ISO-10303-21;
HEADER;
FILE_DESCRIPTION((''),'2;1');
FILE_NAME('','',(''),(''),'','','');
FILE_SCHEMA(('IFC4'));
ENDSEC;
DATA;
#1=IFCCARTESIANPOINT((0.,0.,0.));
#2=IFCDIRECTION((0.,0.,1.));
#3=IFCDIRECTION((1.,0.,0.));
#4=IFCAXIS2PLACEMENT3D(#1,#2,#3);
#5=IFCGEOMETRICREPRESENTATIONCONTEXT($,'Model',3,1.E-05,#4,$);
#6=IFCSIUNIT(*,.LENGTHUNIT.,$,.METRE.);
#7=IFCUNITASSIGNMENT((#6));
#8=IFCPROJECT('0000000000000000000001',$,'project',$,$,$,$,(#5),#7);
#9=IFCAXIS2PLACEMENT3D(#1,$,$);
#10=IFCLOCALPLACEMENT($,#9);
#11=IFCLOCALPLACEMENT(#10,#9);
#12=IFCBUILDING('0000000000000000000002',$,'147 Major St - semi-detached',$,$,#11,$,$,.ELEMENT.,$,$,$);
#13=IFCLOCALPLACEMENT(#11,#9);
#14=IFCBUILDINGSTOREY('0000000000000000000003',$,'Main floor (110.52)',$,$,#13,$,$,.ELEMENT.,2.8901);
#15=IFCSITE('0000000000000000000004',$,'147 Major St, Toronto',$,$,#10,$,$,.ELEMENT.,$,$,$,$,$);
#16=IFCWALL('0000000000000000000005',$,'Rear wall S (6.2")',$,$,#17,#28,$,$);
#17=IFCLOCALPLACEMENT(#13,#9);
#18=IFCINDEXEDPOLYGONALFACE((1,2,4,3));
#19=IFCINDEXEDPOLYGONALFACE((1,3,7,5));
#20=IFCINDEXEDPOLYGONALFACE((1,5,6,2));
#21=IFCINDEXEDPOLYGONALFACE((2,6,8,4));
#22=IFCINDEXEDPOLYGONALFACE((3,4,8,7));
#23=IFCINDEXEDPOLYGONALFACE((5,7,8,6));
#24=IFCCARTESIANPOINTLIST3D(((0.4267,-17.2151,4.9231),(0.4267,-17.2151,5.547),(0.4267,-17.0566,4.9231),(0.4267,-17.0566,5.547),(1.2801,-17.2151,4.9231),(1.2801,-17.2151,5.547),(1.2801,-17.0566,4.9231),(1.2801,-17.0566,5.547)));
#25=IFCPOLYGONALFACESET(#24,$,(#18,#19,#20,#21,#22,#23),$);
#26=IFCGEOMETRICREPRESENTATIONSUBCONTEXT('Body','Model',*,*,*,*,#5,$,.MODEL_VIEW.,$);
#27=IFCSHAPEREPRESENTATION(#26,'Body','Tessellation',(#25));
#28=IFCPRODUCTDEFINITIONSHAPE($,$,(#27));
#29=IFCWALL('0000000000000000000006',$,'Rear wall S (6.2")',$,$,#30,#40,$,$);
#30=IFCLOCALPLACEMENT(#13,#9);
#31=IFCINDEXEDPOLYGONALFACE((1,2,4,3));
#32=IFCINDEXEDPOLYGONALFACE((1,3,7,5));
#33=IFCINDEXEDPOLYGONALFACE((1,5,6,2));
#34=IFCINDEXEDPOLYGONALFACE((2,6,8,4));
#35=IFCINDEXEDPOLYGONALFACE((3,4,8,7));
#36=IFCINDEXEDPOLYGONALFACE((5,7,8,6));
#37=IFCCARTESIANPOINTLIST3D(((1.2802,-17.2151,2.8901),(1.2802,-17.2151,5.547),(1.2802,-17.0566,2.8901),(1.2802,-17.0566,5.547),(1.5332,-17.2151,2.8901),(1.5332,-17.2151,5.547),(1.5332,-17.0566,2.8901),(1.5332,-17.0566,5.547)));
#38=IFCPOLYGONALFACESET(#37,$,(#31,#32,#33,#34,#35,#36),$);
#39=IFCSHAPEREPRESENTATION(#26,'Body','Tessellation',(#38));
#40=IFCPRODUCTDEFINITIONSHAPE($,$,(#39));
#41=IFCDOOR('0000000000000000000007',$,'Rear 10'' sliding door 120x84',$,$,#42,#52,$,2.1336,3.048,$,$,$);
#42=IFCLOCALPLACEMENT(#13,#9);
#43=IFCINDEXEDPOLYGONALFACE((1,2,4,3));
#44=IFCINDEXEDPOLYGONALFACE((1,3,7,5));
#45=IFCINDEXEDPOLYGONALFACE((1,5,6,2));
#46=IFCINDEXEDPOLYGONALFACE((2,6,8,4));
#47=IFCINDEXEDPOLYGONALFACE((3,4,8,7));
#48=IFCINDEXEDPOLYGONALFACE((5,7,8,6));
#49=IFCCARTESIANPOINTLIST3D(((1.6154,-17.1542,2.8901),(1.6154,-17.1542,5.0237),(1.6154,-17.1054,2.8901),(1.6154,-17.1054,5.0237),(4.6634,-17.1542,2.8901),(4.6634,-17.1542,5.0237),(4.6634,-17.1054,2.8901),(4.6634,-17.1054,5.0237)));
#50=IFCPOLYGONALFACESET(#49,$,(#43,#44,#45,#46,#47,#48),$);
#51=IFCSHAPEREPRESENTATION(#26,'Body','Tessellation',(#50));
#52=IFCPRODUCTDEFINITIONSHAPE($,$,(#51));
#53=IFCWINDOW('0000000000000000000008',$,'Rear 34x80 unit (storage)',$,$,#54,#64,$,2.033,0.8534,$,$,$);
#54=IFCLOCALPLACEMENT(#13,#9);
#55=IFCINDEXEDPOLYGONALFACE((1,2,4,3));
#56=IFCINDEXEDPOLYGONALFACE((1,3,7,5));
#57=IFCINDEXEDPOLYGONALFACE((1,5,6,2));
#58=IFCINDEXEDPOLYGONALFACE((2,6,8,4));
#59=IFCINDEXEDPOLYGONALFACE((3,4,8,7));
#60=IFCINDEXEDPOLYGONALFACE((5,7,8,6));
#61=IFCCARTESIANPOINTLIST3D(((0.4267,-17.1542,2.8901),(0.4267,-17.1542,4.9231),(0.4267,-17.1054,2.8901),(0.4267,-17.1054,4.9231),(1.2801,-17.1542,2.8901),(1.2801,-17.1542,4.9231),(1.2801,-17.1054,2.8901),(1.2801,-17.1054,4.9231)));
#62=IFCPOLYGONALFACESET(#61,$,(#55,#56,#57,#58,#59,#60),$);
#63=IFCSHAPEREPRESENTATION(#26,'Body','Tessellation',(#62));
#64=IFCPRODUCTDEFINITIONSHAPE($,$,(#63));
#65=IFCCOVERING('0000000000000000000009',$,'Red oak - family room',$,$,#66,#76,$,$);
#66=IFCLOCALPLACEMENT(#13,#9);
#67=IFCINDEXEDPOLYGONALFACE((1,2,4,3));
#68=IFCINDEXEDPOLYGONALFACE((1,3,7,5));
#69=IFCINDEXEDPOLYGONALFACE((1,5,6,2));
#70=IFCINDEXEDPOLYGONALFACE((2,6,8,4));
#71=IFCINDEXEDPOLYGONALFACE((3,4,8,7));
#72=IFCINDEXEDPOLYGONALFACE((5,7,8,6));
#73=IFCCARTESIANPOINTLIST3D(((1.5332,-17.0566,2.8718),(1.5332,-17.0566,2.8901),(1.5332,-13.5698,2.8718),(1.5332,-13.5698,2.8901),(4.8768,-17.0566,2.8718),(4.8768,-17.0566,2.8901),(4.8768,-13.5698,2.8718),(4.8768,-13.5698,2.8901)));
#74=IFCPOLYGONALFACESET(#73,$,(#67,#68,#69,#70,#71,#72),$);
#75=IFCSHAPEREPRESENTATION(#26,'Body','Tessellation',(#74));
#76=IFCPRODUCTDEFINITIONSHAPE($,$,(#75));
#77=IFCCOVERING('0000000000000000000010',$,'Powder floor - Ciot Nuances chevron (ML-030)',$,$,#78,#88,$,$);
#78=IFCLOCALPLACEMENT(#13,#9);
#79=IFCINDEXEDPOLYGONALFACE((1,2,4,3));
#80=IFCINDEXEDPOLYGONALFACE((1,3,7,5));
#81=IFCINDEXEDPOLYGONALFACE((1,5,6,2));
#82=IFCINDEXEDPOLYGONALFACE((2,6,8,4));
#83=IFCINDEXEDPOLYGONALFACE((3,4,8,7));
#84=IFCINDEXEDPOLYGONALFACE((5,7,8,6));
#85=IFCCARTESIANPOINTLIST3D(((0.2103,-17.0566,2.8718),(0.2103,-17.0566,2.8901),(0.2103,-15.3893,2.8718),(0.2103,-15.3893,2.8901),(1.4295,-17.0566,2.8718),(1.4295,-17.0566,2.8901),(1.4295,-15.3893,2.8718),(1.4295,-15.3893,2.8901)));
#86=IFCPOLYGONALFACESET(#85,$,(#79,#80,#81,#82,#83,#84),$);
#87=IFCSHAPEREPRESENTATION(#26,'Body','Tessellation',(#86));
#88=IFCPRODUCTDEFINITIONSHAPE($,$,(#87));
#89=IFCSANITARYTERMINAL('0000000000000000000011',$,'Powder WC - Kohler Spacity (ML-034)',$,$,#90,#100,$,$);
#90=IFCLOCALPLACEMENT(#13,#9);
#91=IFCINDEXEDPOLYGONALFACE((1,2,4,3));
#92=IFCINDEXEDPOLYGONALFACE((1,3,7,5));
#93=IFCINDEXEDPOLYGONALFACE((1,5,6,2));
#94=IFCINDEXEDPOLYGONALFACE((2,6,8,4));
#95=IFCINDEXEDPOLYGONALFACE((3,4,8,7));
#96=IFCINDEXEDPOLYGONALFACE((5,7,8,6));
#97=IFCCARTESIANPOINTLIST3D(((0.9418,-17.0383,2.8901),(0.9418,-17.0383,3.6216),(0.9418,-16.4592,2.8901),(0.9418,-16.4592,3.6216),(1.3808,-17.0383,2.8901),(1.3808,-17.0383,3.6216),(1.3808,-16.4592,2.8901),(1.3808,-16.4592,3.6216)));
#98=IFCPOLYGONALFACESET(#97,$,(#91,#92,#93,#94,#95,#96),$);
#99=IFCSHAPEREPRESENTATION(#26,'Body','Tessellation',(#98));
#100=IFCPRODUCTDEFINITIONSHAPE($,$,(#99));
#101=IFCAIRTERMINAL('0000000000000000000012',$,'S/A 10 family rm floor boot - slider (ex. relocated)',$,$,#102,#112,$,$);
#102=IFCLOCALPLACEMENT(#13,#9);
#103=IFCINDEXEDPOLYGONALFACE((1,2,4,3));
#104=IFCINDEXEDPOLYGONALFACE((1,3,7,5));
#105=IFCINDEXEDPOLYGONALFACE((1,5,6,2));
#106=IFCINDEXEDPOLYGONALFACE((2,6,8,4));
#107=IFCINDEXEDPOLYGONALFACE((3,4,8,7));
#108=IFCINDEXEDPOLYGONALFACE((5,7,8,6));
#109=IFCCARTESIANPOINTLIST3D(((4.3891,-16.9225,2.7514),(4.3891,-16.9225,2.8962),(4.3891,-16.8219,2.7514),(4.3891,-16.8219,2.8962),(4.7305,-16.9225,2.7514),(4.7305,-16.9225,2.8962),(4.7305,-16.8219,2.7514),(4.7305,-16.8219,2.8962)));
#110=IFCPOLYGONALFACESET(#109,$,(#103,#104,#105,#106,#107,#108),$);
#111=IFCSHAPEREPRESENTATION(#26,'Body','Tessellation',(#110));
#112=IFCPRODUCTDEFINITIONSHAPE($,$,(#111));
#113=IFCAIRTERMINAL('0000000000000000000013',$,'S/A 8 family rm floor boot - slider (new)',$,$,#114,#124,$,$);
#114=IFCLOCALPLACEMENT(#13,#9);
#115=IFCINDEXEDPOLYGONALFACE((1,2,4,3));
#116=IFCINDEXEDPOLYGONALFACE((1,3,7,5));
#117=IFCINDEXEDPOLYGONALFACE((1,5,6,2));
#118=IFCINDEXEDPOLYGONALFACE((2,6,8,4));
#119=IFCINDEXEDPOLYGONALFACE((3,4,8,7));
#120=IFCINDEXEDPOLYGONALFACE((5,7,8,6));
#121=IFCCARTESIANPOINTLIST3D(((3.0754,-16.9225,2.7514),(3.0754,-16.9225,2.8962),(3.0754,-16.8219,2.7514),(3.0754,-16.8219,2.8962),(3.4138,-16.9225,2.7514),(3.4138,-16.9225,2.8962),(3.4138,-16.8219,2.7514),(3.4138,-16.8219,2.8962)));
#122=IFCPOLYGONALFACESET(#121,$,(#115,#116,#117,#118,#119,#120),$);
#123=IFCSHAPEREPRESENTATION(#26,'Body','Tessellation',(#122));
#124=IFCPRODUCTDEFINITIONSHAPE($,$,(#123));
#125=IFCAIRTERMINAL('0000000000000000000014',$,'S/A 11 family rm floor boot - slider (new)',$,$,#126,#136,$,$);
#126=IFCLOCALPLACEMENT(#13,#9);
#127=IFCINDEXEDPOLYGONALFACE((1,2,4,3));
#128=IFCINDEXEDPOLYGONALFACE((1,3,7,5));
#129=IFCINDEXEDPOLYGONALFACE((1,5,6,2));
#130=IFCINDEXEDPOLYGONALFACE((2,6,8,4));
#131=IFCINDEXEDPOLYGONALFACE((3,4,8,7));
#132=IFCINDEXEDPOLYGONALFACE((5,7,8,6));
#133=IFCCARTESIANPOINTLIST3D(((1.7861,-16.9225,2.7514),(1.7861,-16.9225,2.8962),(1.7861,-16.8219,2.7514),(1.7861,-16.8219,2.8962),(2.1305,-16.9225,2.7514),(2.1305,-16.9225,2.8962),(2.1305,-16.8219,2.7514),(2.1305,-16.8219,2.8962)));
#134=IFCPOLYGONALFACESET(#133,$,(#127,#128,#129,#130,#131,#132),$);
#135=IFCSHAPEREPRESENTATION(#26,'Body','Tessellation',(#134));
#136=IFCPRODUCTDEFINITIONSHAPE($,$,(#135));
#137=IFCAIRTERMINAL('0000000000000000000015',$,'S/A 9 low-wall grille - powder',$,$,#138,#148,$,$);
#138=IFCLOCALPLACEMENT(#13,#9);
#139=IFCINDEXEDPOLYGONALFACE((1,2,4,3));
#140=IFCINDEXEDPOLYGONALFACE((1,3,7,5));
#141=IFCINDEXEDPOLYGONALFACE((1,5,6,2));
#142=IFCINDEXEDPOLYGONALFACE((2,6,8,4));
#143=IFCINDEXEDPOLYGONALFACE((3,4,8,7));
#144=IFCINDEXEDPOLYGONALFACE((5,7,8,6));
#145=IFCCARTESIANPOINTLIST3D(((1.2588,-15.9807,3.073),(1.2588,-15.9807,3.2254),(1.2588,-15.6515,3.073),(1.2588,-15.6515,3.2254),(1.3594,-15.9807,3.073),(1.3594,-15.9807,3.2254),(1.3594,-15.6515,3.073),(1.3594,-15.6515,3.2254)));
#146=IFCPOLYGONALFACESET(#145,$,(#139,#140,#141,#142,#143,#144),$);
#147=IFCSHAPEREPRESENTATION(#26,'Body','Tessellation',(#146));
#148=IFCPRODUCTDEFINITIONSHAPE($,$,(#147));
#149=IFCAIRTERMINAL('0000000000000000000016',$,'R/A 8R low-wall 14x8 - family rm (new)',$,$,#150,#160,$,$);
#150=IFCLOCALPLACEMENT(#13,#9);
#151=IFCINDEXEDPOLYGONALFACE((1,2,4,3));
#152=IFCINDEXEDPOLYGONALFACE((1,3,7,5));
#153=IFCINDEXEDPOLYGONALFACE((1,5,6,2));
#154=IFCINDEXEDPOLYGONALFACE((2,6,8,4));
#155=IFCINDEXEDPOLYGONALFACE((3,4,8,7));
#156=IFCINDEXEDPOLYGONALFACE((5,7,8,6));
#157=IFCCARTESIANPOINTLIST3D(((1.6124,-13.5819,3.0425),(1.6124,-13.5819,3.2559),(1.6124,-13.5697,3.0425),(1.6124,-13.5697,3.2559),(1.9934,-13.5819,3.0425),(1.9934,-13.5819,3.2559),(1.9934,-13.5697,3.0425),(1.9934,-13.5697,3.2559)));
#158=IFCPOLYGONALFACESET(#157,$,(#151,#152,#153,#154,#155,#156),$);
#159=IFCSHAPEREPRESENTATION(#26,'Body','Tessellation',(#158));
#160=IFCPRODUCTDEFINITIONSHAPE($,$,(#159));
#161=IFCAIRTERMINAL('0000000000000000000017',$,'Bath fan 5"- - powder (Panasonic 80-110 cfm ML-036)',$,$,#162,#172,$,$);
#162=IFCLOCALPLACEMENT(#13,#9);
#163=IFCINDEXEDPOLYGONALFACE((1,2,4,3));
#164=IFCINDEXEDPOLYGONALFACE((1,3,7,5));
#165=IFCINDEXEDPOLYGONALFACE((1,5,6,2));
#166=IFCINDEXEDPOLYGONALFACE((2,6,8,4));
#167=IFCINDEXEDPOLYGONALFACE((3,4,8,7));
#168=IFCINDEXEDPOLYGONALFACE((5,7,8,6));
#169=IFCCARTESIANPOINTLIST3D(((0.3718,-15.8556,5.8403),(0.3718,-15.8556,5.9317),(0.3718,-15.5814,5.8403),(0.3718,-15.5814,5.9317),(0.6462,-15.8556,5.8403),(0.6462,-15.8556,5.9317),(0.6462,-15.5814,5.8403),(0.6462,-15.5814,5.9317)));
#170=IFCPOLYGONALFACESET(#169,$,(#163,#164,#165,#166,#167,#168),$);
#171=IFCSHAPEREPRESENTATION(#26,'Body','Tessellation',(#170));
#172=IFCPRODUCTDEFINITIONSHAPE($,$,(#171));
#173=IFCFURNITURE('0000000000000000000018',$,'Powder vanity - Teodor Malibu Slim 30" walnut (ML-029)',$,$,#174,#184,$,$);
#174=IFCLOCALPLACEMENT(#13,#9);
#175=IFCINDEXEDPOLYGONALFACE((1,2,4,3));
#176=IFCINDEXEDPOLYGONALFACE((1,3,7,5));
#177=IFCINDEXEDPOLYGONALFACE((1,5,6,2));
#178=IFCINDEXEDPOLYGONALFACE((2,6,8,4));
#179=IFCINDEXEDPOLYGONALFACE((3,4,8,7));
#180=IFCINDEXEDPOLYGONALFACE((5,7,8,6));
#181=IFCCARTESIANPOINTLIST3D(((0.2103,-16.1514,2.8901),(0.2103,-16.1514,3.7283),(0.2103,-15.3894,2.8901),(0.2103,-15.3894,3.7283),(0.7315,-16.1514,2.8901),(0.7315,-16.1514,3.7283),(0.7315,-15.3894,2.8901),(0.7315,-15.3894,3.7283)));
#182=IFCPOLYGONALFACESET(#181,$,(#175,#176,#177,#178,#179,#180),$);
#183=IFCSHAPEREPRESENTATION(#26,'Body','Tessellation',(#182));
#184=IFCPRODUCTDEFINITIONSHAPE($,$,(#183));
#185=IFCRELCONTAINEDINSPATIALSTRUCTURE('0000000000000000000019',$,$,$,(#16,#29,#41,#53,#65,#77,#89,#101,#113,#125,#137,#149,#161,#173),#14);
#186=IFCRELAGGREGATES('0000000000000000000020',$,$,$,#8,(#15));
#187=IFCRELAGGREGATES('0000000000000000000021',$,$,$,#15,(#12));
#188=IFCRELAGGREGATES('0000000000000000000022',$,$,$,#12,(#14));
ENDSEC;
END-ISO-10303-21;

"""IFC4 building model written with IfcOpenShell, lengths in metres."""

from ifc_helpers import new_model, si_unit, frame, origin, origin_with_axes, place, context, subcontext, project, spatial, rectangle, extrude, element, save


model = new_model("IFC4")

# Units and contexts
model_context = context("Model", 3, precision=1e-05, world=origin_with_axes())
body_context = subcontext(model_context, "Body", "Model", "MODEL_VIEW")
ifc_project = project(units=[si_unit("LENGTHUNIT", "METRE")], contexts=[model_context])

# Site, building, storey
site_placement = place(None, origin())
site = spatial("IfcSite", under=ifc_project, at=site_placement, Name="147 Major St, Toronto", CompositionType="ELEMENT")
building_placement = place(site_placement, origin())
building = spatial("IfcBuilding", under=site, at=building_placement, Name="147 Major St - semi-detached", CompositionType="ELEMENT")
storey_placement = place(building_placement, origin())
storey = spatial("IfcBuildingStorey", under=building, at=storey_placement, Name="Main floor (110.52)", CompositionType="ELEMENT", Elevation=2.8901)

# Walls
wall_1_placement = place(storey_placement, frame((0.8534, -17.1359, 4.9231)))
element("IfcWall", 1, at=wall_1_placement, inside=storey, Name="Rear wall S (6.2\")", context=body_context, shape_type="SweptSolid", body=[
    extrude(rectangle(XDim=0.8534, YDim=0.1585), origin_with_axes(), (0.0, 0.0, 1.0), 0.6239),
])
wall_2_placement = place(storey_placement, frame((1.4067, -17.1359, 2.8901)))
element("IfcWall", 2, at=wall_2_placement, inside=storey, Name="Rear wall S (6.2\")", context=body_context, shape_type="SweptSolid", body=[
    extrude(rectangle(XDim=0.253, YDim=0.1585), origin_with_axes(), (0.0, 0.0, 1.0), 2.6569),
])

# Door
door_placement = place(storey_placement, frame((3.1394, -17.1298, 2.8901)))
element("IfcDoor", 3, at=door_placement, inside=storey, Name="Rear 10' sliding door 120x84", OverallHeight=2.1336, OverallWidth=3.048, context=body_context, shape_type="SweptSolid", body=[
    extrude(rectangle(XDim=3.048, YDim=0.0488), origin_with_axes(), (0.0, 0.0, 1.0), 2.1336),
])

# Window
window_placement = place(storey_placement, frame((0.8534, -17.1298, 2.8901)))
element("IfcWindow", 4, at=window_placement, inside=storey, Name="Rear 34x80 unit (storage)", OverallHeight=2.033, OverallWidth=0.8534, context=body_context, shape_type="SweptSolid", body=[
    extrude(rectangle(XDim=0.8534, YDim=0.0488), origin_with_axes(), (0.0, 0.0, 1.0), 2.033),
])

# Coverings
covering_1_placement = place(storey_placement, frame((3.205, -15.3132, 2.8718)))
element("IfcCovering", 5, at=covering_1_placement, inside=storey, Name="Red oak - family room", context=body_context, shape_type="SweptSolid", body=[
    extrude(rectangle(XDim=3.3437, YDim=3.4869), origin_with_axes(), (0.0, 0.0, 1.0), 0.0183),
])
covering_2_placement = place(storey_placement, frame((0.8199, -16.223, 2.8718)))
element("IfcCovering", 6, at=covering_2_placement, inside=storey, Name="Powder floor - Ciot Nuances chevron (ML-030)", context=body_context, shape_type="SweptSolid", body=[
    extrude(rectangle(XDim=1.2192, YDim=1.6673), origin_with_axes(), (0.0, 0.0, 1.0), 0.0183),
])

# Sanitary terminal
sanitary_terminal_placement = place(storey_placement, frame((1.1613, -16.7488, 2.8901)))
element("IfcSanitaryTerminal", 7, at=sanitary_terminal_placement, inside=storey, Name="Powder WC - Kohler Spacity (ML-034)", context=body_context, shape_type="SweptSolid", body=[
    extrude(rectangle(XDim=0.4389, YDim=0.5791), origin_with_axes(), (0.0, 0.0, 1.0), 0.7315),
])

# Air terminals
air_terminal_1_placement = place(storey_placement, frame((4.5598, -16.8722, 2.7514)))
element("IfcAirTerminal", 8, at=air_terminal_1_placement, inside=storey, Name="S/A 10 family rm floor boot - slider (ex. relocated)", context=body_context, shape_type="SweptSolid", body=[
    extrude(rectangle(XDim=0.3414, YDim=0.1006), origin_with_axes(), (0.0, 0.0, 1.0), 0.1448),
])
air_terminal_2_placement = place(storey_placement, frame((3.2446, -16.8722, 2.7514)))
element("IfcAirTerminal", 9, at=air_terminal_2_placement, inside=storey, Name="S/A 8 family rm floor boot - slider (new)", context=body_context, shape_type="SweptSolid", body=[
    extrude(rectangle(XDim=0.3383, YDim=0.1006), origin_with_axes(), (0.0, 0.0, 1.0), 0.1448),
])
air_terminal_3_placement = place(storey_placement, frame((1.9583, -16.8722, 2.7514)))
element("IfcAirTerminal", 10, at=air_terminal_3_placement, inside=storey, Name="S/A 11 family rm floor boot - slider (new)", context=body_context, shape_type="SweptSolid", body=[
    extrude(rectangle(XDim=0.3444, YDim=0.1006), origin_with_axes(), (0.0, 0.0, 1.0), 0.1448),
])
air_terminal_4_placement = place(storey_placement, frame((1.3091, -15.8161, 3.073)))
element("IfcAirTerminal", 11, at=air_terminal_4_placement, inside=storey, Name="S/A 9 low-wall grille - powder", context=body_context, shape_type="SweptSolid", body=[
    extrude(rectangle(XDim=0.1006, YDim=0.3292), origin_with_axes(), (0.0, 0.0, 1.0), 0.1524),
])
air_terminal_5_placement = place(storey_placement, frame((1.8029, -13.5758, 3.0425)))
element("IfcAirTerminal", 12, at=air_terminal_5_placement, inside=storey, Name="R/A 8R low-wall 14x8 - family rm (new)", context=body_context, shape_type="SweptSolid", body=[
    extrude(rectangle(XDim=0.381, YDim=0.0122), origin_with_axes(), (0.0, 0.0, 1.0), 0.2134),
])
air_terminal_6_placement = place(storey_placement, frame((0.509, -15.7185, 5.8403)))
element("IfcAirTerminal", 13, at=air_terminal_6_placement, inside=storey, Name="Bath fan 5\"- - powder (Panasonic 80-110 cfm ML-036)", context=body_context, shape_type="SweptSolid", body=[
    extrude(rectangle(XDim=0.2743, YDim=0.2743), origin_with_axes(), (0.0, 0.0, 1.0), 0.0914),
])

# Furniture
furniture_placement = place(storey_placement, frame((0.4709, -15.7704, 2.8901)))
element("IfcFurniture", 14, at=furniture_placement, inside=storey, Name="Powder vanity - Teodor Malibu Slim 30\" walnut (ML-029)", context=body_context, shape_type="SweptSolid", body=[
    extrude(rectangle(XDim=0.5212, YDim=0.762), origin_with_axes(), (0.0, 0.0, 1.0), 0.8382),
])

save(model, "model.ifc")
